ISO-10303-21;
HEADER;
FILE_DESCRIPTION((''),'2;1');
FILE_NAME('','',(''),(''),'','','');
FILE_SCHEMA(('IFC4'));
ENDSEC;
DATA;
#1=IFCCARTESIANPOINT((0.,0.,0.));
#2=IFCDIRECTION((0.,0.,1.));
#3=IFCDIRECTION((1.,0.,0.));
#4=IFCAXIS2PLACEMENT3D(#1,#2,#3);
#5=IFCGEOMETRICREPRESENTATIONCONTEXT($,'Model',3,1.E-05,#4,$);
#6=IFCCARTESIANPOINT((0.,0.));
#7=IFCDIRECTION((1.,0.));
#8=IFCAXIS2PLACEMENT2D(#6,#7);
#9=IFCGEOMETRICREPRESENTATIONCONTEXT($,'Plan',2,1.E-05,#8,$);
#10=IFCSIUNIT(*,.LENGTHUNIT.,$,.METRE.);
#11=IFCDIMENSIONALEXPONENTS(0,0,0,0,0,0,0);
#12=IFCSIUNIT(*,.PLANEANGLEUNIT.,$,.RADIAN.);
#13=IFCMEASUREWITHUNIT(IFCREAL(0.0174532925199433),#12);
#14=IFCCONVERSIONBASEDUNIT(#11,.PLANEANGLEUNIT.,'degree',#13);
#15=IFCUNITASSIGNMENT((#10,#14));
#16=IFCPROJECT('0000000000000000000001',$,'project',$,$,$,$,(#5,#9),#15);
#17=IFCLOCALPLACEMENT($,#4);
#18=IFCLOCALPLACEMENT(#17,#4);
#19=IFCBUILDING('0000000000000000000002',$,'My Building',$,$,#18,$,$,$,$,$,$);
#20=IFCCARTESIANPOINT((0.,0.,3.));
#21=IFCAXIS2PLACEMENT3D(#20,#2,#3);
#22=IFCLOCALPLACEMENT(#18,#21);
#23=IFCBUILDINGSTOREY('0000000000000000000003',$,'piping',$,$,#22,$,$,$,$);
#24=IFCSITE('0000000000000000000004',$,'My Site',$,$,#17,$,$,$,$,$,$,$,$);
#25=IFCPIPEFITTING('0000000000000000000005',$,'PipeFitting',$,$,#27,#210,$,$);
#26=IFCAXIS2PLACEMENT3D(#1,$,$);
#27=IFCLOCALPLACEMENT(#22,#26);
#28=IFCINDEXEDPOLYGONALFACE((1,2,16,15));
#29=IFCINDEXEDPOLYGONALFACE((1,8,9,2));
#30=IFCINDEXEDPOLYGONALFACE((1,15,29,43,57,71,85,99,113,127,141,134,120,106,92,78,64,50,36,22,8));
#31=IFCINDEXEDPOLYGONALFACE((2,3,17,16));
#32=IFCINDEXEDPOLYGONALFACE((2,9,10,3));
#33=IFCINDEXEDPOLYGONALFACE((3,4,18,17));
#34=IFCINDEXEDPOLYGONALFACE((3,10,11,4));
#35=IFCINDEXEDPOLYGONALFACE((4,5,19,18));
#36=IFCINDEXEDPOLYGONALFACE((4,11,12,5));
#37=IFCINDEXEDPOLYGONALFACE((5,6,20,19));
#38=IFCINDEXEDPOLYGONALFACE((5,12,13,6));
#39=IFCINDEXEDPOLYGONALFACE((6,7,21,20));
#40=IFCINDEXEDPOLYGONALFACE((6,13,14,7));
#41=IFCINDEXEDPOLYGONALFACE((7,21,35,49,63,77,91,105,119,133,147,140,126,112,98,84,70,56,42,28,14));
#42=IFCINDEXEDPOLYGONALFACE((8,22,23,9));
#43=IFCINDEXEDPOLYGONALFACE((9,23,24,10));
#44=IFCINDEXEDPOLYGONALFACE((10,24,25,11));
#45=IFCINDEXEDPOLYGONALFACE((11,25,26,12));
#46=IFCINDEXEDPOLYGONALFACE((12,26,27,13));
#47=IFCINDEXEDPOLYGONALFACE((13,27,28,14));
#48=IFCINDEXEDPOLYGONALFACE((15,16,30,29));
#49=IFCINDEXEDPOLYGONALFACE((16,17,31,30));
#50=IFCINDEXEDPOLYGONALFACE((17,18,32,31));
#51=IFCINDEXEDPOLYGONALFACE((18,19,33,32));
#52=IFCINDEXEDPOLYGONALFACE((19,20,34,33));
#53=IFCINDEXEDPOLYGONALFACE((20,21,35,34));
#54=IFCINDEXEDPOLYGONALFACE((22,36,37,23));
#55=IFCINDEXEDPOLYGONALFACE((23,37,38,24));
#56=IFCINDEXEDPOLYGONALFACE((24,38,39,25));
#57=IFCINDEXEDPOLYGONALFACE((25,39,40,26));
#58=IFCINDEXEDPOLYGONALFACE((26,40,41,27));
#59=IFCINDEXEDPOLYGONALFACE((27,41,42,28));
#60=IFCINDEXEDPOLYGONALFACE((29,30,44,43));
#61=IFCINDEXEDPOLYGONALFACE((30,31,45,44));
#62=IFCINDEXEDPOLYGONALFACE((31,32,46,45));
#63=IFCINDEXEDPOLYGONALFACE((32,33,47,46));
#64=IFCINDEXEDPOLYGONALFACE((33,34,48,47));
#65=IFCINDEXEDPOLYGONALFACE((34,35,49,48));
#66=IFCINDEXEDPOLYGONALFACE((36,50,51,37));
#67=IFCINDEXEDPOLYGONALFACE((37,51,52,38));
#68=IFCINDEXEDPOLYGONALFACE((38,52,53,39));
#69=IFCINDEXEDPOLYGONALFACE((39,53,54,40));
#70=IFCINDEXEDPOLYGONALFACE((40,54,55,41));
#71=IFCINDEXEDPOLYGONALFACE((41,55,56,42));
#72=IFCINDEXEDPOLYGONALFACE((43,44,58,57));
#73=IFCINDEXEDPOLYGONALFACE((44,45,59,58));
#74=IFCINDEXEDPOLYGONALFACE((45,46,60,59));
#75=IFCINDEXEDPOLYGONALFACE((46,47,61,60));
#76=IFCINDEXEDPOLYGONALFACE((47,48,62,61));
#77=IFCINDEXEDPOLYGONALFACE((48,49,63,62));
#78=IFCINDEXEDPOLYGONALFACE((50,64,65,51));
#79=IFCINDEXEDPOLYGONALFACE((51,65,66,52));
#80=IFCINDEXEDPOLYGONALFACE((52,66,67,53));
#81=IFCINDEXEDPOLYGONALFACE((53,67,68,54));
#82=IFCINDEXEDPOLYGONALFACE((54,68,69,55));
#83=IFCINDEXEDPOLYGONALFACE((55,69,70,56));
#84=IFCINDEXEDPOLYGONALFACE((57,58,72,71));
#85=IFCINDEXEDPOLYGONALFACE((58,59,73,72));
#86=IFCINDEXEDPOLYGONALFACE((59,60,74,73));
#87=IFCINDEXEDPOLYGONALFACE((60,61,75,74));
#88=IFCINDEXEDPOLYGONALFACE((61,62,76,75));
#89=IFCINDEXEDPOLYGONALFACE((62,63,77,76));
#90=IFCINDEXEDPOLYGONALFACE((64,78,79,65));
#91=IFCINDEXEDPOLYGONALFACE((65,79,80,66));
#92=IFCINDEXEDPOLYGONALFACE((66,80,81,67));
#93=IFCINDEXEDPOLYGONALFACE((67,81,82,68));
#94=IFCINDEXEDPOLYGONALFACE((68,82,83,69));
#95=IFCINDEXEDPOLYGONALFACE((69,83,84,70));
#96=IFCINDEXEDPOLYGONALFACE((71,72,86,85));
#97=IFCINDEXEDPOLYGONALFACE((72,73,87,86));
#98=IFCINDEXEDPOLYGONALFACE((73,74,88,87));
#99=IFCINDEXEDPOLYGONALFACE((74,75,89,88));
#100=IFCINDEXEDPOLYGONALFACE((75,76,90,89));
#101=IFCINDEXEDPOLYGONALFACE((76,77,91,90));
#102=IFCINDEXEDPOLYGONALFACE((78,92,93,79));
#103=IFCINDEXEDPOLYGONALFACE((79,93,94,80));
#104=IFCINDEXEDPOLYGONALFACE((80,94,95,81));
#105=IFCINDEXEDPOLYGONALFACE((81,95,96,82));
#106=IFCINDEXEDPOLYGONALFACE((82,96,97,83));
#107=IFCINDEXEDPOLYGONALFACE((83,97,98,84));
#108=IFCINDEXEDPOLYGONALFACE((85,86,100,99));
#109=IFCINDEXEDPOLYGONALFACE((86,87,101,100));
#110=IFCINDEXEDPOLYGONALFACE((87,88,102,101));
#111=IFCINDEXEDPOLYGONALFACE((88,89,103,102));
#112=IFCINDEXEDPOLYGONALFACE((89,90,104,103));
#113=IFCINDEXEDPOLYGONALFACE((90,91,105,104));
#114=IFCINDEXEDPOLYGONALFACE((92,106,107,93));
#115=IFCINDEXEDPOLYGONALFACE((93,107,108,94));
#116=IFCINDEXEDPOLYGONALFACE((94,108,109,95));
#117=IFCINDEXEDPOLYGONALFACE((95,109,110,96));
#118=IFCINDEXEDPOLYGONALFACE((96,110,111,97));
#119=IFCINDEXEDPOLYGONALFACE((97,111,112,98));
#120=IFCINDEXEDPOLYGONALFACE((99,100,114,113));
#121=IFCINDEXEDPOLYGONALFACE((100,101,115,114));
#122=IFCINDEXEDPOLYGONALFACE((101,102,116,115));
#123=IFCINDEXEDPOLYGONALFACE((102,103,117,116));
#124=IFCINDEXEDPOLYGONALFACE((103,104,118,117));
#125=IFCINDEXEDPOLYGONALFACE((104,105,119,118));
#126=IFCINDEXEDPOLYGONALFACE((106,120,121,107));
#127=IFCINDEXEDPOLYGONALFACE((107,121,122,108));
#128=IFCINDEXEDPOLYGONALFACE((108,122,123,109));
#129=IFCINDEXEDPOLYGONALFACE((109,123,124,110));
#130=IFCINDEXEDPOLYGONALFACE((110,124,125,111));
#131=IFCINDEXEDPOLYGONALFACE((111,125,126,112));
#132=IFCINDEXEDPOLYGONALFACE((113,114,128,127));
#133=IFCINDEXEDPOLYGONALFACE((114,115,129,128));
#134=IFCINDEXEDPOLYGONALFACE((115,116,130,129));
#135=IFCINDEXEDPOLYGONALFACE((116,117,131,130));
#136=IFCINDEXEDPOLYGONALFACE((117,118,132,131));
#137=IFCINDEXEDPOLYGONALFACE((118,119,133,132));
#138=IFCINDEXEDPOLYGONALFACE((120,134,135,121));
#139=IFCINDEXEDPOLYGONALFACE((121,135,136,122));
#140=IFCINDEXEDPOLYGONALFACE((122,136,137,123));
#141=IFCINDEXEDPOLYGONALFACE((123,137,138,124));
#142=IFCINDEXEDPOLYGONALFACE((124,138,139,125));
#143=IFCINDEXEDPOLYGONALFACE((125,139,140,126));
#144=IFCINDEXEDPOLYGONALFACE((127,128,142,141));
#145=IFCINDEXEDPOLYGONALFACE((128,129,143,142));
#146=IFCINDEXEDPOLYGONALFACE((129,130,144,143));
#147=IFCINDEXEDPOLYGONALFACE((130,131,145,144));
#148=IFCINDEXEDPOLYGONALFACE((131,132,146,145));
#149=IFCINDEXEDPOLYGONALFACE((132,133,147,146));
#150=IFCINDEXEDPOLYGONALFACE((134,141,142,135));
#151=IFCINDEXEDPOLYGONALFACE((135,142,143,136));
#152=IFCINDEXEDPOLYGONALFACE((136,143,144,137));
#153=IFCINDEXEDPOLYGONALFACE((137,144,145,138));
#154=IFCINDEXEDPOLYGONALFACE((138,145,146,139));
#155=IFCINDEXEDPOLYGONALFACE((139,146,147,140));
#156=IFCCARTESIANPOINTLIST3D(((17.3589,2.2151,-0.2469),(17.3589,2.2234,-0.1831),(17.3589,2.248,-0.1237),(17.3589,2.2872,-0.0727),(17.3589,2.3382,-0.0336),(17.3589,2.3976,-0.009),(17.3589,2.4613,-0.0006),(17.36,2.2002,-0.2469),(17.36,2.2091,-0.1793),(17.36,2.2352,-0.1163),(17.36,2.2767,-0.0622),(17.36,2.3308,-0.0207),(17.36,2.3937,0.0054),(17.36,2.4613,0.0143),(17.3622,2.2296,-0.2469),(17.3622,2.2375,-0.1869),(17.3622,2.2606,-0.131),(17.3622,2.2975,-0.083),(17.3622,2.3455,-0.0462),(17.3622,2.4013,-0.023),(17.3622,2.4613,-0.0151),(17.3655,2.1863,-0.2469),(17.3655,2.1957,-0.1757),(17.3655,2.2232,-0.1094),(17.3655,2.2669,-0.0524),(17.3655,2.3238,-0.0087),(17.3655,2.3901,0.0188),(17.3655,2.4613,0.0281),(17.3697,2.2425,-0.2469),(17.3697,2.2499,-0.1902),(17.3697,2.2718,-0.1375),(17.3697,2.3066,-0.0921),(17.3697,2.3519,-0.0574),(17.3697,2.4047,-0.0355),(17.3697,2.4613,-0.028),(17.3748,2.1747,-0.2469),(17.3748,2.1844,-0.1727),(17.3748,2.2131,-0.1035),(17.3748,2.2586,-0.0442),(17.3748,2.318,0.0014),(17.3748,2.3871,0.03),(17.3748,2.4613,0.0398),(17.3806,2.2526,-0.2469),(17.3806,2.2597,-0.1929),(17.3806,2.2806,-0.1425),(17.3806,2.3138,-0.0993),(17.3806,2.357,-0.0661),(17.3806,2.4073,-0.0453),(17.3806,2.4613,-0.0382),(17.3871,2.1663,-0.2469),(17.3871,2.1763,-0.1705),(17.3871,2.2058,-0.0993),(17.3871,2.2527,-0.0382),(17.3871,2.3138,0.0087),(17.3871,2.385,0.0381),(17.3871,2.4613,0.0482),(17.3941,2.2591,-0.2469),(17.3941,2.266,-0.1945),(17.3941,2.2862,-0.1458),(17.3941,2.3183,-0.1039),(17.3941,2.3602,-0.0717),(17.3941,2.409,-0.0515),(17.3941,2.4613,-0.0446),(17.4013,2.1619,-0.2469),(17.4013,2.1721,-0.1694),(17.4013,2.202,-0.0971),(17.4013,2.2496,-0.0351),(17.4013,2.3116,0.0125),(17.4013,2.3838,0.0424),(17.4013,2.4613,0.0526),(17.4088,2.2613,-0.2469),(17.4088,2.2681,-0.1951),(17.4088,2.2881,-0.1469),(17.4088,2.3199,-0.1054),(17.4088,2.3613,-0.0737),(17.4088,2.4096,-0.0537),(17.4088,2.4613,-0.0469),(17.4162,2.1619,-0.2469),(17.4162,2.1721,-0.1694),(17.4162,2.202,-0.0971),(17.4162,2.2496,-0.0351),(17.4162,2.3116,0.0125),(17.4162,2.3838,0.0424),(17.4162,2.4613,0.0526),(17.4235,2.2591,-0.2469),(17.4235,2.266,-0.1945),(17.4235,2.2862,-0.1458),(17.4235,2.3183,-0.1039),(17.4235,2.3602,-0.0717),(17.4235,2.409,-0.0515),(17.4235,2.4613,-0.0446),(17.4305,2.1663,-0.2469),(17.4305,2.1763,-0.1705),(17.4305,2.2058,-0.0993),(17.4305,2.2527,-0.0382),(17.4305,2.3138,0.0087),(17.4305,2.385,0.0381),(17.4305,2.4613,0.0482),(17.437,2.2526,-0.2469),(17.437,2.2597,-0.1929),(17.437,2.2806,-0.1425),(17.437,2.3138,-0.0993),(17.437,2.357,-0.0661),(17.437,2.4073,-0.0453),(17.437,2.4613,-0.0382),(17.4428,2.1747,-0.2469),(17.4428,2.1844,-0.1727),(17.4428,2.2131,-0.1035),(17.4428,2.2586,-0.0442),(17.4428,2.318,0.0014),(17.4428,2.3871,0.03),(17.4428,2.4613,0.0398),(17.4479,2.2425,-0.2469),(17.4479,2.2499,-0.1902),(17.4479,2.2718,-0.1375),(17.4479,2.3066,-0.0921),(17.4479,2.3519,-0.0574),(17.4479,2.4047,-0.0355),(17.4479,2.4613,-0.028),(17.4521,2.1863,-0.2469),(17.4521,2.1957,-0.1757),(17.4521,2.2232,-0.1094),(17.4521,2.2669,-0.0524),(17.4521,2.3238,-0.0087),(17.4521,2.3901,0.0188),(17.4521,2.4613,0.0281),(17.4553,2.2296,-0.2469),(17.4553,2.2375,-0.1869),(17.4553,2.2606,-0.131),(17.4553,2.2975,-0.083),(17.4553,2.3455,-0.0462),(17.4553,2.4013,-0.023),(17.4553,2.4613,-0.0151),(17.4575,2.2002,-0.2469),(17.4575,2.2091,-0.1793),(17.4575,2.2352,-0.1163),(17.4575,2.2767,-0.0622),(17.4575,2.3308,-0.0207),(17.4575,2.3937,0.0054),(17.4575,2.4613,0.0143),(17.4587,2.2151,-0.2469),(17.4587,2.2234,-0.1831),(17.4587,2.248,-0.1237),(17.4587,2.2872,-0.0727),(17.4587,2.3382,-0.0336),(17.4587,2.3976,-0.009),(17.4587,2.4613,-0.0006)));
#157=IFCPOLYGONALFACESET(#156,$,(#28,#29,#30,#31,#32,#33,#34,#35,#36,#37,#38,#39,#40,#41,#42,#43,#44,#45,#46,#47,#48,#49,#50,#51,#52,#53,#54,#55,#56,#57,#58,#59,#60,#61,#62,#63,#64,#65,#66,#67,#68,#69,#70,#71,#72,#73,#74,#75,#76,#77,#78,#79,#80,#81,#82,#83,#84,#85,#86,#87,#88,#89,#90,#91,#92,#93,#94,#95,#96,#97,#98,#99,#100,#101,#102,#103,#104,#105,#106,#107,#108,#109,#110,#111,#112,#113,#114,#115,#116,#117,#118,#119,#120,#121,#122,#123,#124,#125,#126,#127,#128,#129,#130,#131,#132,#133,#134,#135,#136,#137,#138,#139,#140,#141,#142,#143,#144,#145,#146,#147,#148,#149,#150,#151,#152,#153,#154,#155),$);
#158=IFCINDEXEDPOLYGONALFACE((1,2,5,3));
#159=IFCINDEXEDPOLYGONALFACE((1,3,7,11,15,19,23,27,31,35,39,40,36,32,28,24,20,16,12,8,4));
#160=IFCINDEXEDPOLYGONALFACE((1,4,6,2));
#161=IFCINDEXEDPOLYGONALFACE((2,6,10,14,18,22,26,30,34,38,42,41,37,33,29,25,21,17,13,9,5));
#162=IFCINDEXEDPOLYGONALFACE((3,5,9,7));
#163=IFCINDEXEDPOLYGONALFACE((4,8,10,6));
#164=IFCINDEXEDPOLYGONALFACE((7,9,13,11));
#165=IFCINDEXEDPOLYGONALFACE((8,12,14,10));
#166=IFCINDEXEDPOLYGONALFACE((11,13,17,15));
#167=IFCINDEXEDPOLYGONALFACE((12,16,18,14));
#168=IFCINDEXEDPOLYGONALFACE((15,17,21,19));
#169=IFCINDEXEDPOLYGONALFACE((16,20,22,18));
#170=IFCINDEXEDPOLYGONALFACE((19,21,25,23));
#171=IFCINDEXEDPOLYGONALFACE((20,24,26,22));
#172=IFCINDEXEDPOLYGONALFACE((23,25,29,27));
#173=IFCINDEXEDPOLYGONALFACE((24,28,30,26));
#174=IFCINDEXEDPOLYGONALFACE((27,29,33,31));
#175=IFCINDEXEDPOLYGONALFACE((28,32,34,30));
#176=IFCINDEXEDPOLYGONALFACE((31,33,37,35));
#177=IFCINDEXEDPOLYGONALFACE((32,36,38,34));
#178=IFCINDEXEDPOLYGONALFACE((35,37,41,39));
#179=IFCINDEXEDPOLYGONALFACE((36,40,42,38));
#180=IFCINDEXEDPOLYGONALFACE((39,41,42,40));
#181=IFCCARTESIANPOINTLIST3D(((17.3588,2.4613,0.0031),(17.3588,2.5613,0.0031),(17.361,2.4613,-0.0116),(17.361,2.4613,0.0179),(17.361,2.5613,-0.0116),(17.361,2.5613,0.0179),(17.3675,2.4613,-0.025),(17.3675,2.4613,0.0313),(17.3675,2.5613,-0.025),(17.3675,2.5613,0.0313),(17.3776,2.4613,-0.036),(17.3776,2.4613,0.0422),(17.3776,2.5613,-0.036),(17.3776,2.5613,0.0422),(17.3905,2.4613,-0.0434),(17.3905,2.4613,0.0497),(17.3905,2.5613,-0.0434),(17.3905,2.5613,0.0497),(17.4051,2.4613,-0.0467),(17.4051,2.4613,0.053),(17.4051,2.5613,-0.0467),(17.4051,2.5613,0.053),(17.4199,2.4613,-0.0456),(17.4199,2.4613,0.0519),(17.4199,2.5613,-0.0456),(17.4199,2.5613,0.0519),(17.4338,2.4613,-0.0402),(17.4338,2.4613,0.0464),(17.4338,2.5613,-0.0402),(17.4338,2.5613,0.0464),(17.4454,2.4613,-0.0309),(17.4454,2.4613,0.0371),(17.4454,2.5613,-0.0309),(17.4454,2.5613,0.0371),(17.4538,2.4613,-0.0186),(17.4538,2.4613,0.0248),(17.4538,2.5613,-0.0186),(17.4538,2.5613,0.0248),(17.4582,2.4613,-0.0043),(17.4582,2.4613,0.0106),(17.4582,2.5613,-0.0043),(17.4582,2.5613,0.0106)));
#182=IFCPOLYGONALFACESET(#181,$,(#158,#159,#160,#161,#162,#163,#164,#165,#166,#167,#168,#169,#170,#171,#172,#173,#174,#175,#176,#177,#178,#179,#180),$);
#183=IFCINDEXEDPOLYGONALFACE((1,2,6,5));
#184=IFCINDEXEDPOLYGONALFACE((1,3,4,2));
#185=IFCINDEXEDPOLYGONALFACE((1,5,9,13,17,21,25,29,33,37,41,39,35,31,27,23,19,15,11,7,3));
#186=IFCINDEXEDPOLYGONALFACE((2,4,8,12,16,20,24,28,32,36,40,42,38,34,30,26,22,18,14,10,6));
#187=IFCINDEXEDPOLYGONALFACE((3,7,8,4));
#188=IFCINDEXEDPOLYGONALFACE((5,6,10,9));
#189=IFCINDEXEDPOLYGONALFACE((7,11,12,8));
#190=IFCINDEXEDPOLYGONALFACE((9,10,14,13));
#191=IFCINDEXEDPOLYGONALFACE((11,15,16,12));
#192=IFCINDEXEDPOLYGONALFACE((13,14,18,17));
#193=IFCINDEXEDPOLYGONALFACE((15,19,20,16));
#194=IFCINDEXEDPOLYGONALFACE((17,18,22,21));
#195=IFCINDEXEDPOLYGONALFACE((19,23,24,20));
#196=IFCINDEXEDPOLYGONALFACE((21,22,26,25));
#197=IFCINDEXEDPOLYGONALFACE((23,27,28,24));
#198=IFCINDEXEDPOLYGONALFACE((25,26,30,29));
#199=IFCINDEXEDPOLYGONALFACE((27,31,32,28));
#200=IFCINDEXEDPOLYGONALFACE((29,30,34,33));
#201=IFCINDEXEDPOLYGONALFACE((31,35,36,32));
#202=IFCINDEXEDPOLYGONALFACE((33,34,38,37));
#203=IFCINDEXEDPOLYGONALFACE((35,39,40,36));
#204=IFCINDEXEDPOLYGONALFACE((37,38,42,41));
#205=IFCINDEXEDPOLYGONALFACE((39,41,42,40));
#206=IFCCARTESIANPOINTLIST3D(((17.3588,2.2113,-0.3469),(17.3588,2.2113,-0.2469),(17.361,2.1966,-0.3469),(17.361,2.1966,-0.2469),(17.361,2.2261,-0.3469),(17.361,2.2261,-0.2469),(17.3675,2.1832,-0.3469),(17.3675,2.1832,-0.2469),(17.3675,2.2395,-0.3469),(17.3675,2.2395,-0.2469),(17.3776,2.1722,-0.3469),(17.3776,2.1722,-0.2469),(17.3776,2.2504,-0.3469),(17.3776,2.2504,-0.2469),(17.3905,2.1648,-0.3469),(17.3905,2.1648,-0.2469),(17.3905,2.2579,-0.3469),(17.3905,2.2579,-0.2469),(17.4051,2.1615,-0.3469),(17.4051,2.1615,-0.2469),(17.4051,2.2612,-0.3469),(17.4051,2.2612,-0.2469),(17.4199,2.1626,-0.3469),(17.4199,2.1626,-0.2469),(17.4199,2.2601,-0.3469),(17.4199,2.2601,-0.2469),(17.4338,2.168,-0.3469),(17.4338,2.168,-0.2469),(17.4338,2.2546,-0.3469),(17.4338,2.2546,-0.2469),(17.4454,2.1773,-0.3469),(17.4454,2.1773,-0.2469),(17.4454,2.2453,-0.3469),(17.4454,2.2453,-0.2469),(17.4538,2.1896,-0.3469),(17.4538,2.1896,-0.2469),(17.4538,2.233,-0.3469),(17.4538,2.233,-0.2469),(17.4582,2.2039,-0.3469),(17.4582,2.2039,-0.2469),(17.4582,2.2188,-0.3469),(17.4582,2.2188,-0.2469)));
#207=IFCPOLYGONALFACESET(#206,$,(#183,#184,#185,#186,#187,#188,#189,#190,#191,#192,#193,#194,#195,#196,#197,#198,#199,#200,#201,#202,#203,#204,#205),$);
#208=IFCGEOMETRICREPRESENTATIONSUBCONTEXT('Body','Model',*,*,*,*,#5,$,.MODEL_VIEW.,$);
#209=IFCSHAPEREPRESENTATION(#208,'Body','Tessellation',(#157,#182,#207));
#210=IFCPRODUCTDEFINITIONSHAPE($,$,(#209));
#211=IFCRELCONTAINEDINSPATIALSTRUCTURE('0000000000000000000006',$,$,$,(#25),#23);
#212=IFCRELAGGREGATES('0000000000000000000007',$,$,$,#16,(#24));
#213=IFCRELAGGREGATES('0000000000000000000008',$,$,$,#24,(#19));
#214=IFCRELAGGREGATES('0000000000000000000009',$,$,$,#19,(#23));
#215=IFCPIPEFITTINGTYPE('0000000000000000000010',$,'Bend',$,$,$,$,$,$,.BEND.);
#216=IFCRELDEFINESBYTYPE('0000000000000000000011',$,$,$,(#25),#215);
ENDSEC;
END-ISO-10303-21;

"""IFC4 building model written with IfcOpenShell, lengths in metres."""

from ifc_helpers import new_model, entity, si_unit, converted_unit, frame, origin_with_axes, origin_2d_with_axis, place, context, subcontext, project, spatial, circle, extrude, source, transform, mapped, type_object, type_shapes, element, save


model = new_model("IFC4")

# Units and contexts
model_context = context("Model", 3, precision=1e-05, world=origin_with_axes())
plan_context = context("Plan", 2, precision=1e-05, world=origin_2d_with_axis())
body_context = subcontext(model_context, "Body", "Model", "MODEL_VIEW")
ifc_project = project(units=[si_unit("LENGTHUNIT", "METRE"), converted_unit("PLANEANGLEUNIT", "degree", entity("IfcReal", 0.0174532925199433), si_unit("PLANEANGLEUNIT", "RADIAN"), dimensions=[0, 0, 0, 0, 0, 0, 0])], contexts=[model_context, plan_context])

# Site, building, storey
site_placement = place(None, origin_with_axes())
site = spatial("IfcSite", under=ifc_project, at=site_placement, Name="My Site")
building_placement = place(site_placement, origin_with_axes())
building = spatial("IfcBuilding", under=site, at=building_placement, Name="My Building")
storey_placement = place(building_placement, frame((0.0, 0.0, 3.0), z_axis=(0.0, 0.0, 1.0), x_axis=(1.0, 0.0, 0.0)))
storey = spatial("IfcBuildingStorey", under=building, at=storey_placement, Name="piping")

# Pipe fitting
pipe_fitting_type = type_object("IfcPipeFittingType", Name="Bend", PredefinedType="BEND")
shared_shape = source(origin_with_axes(), body_context, "Body", "SolidModel", [
    entity("IfcSweptDiskSolid", entity("IfcIndexedPolyCurve", entity("IfcCartesianPointList3D", [[0.0, 0.0, -0.1], [0.0, -0.0732, -0.2768], [0.0, -0.25, -0.35]]), [entity("IfcArcIndex", [1, 2, 3])]), 0.05),
    extrude(circle(Radius=0.05), origin_with_axes(), (0.0, 0.0, -1.0), 0.1),
    extrude(circle(Radius=0.05), frame((0.0, -0.25, -0.35), z_axis=(0.0, -1.0, 0.0), x_axis=(1.0, 0.0, 0.0)), (0.0, 0.0, 1.0), 0.1),
])
type_shapes(pipe_fitting_type, [shared_shape])
for number, where, z_axis, x_axis, name in (
    (1, (17.4088, 2.5613, 0.0031), (0.0, 1.0, 0.0), (-1.0, 0.0, 0.0), "PipeFitting"),
):
    element("IfcPipeFitting", number, at=place(storey_placement, frame(where, z_axis=z_axis, x_axis=x_axis)), inside=storey, type_object=pipe_fitting_type, Name=name, context=body_context, shape_type="MappedRepresentation", body=[
        mapped(shared_shape, transform((0.0, 0.0, 0.0), x_axis=(1.0, 0.0, 0.0), y_axis=(0.0, 1.0, 0.0), z_axis=(0.0, 0.0, 1.0), scale=1.0)),
    ])

save(model, "model.ifc")
